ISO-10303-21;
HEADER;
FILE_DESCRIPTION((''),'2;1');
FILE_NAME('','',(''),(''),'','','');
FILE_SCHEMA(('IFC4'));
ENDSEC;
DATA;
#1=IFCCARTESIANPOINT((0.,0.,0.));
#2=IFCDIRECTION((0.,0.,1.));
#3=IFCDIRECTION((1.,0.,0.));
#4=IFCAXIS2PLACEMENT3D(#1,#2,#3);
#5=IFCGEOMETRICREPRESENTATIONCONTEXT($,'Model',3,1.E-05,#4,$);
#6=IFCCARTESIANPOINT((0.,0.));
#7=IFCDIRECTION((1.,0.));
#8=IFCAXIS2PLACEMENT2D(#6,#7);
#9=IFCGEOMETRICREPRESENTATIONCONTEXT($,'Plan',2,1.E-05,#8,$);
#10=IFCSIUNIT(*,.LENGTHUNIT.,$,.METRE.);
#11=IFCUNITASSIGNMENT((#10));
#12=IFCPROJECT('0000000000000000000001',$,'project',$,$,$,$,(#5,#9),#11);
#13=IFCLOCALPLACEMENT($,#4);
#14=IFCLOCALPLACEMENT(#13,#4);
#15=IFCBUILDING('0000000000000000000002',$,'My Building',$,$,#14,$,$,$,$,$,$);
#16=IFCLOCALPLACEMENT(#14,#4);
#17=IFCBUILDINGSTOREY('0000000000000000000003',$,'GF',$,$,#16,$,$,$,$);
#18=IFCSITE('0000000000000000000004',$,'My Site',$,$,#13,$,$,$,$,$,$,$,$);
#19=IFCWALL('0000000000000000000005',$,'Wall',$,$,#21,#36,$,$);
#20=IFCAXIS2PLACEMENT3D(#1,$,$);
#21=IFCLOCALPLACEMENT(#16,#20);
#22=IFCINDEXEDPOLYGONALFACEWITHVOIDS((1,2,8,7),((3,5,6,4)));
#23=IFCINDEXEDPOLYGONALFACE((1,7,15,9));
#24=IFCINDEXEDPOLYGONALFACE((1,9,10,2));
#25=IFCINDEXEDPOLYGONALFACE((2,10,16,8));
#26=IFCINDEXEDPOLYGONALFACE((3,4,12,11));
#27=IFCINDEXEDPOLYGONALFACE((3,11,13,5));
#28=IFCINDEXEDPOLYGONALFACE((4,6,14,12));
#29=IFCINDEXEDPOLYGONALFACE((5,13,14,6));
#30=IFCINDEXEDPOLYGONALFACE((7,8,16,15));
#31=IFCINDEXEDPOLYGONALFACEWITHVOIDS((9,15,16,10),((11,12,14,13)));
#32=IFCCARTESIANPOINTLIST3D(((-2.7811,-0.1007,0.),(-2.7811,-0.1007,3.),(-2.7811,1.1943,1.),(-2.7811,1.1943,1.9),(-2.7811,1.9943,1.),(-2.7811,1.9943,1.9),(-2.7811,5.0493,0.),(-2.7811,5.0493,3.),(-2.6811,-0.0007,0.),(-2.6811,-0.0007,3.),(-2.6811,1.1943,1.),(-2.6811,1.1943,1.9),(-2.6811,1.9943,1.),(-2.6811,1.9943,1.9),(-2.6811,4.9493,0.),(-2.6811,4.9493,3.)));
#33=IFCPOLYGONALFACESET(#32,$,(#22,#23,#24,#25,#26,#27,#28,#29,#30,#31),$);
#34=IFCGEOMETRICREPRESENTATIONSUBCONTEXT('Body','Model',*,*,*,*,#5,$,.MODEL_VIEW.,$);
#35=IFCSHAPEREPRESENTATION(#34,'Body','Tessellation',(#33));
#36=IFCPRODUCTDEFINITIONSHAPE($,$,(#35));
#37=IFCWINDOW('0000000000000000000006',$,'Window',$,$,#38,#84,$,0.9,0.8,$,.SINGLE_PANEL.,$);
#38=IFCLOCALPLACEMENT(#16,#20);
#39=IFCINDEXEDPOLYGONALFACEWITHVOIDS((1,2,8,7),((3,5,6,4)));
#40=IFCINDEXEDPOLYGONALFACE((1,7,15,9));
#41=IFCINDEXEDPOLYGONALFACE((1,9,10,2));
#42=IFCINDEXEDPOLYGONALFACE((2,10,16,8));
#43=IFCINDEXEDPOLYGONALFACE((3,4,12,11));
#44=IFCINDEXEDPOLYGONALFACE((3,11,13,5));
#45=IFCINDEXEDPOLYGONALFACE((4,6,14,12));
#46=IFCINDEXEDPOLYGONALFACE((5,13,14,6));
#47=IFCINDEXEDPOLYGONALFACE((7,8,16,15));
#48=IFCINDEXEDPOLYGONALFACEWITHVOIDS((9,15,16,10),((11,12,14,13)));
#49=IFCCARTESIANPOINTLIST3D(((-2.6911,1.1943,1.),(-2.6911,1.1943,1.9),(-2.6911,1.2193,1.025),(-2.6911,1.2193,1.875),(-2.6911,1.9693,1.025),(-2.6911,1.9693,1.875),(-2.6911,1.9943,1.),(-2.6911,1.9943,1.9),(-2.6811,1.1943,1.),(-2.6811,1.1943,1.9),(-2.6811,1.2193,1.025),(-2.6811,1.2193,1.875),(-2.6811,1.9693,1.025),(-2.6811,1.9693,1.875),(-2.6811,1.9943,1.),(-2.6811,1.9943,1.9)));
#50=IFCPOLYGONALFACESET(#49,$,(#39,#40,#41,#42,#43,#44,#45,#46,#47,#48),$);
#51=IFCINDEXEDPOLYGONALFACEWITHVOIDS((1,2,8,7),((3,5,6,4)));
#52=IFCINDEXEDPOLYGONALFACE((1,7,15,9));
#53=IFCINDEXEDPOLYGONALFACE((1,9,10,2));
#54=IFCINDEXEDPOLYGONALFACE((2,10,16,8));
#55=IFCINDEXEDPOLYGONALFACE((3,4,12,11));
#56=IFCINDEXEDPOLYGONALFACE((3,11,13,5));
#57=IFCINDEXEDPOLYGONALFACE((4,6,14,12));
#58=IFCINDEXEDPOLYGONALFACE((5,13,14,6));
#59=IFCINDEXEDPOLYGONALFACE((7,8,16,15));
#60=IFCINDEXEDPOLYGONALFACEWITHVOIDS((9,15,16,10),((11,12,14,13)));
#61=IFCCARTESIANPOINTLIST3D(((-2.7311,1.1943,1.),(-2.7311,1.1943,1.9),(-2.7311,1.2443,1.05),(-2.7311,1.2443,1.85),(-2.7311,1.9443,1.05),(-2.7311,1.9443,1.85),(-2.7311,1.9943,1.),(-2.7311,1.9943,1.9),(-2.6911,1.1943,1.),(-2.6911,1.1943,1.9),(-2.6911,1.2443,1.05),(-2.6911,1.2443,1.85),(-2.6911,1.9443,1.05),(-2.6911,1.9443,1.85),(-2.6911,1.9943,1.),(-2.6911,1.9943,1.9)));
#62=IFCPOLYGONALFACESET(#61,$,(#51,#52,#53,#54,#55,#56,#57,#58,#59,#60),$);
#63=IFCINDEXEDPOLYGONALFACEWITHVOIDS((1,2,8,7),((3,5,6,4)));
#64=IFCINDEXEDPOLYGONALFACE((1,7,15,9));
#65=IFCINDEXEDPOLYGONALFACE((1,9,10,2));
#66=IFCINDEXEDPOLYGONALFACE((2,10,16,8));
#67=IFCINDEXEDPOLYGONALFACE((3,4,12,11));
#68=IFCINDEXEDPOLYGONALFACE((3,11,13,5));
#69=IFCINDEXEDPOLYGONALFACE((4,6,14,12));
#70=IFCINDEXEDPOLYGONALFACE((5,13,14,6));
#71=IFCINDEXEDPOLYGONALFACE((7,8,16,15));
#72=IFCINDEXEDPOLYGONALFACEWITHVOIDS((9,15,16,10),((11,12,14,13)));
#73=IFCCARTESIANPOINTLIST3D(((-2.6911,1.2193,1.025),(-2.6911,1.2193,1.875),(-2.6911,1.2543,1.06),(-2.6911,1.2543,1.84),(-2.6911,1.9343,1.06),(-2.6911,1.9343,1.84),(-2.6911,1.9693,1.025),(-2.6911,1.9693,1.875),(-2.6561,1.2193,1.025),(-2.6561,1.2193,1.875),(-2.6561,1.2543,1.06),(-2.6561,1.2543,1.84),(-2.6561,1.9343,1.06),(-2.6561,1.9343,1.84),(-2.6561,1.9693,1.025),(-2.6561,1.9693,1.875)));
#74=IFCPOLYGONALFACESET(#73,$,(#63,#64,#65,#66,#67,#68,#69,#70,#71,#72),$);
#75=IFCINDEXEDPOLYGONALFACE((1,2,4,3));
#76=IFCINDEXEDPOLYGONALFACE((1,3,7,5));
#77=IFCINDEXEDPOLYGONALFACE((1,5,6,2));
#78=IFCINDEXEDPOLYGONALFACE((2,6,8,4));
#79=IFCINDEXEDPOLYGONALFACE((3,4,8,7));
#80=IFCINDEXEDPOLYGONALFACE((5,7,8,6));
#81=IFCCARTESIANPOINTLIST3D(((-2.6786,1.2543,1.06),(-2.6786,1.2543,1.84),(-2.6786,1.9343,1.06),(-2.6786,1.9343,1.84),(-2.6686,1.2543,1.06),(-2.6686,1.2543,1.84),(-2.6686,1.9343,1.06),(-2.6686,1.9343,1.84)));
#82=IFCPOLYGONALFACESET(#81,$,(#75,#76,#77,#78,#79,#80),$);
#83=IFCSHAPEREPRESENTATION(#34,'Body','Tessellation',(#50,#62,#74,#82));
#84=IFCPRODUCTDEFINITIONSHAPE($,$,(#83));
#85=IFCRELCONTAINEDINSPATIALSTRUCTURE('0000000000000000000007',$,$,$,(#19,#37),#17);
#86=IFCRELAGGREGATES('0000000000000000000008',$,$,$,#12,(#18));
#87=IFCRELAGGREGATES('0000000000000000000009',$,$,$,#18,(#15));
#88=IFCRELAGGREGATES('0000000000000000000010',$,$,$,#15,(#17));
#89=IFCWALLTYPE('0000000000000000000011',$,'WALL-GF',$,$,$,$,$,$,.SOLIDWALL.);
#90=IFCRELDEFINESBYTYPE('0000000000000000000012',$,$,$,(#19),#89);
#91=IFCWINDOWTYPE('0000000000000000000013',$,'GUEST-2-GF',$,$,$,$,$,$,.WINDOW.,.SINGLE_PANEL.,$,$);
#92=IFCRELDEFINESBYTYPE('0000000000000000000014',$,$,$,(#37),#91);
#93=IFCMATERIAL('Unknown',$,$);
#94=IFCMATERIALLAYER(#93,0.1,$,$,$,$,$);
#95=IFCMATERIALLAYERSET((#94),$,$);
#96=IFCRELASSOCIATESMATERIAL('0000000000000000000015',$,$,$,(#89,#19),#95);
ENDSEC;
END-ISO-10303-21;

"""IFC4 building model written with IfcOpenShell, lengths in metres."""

from ifc_helpers import new_model, entity, si_unit, frame, origin_with_axes, origin_2d_with_axis, place, context, subcontext, project, spatial, line, indexed_curve, outline, extrude, shape, source, transform, mapped, material, layer, layer_set, layer_usage, type_object, type_shapes, element, fill, save


model = new_model("IFC4")

# Units and contexts
model_context = context("Model", 3, precision=1e-05, world=origin_with_axes())
plan_context = context("Plan", 2, precision=1e-05, world=origin_2d_with_axis())
body_context_1 = subcontext(model_context, "Body", "Model", "MODEL_VIEW")
body_context_2 = subcontext(plan_context, "Body", "Plan", "PLAN_VIEW")
ifc_project = project(units=[si_unit("LENGTHUNIT", "METRE")], contexts=[model_context, plan_context])

# Site, building, storey
site_placement = place(None, origin_with_axes())
site = spatial("IfcSite", under=ifc_project, at=site_placement, Name="My Site")
building_placement = place(site_placement, origin_with_axes())
building = spatial("IfcBuilding", under=site, at=building_placement, Name="My Building")
storey_placement = place(building_placement, origin_with_axes())
storey = spatial("IfcBuildingStorey", under=building, at=storey_placement, Name="GF")

# Shared definitions
ifc_material = material(Name="Unknown")

# Shared definitions
ifc_layer_1 = layer(ifc_material, 0.1)
ifc_layer_set_1 = layer_set([ifc_layer_1])
wall_type = type_object("IfcWallType", Name="WALL-GF", PredefinedType="SOLIDWALL", material=ifc_layer_set_1)

# Wall, opening, window
ifc_layer_usage_1 = layer_usage(ifc_layer_set_1, "AXIS2", "POSITIVE", 0.0)
wall_1_placement = place(storey_placement, frame((-2.7811, 5.0493, 0.0), z_axis=(0.0, 0.0, 1.0), x_axis=(0.0, -1.0, 0.0)))
wall_1 = element("IfcWall", 1, at=wall_1_placement, inside=storey, type_object=wall_type, material=ifc_layer_usage_1, Name="Wall", context=body_context_1, shape_type="SweptSolid", body=[
    extrude(outline(indexed_curve([(0.0, 0.0), (0.1, 0.1), (5.05, 0.1), (5.15, 0.0)], segments=[line(1, 2, 3, 4, 1)])), origin_with_axes(), (0.0, 0.0, 1.0), 3.0),
])
shared_shape_1 = source(origin_with_axes(), body_context_1, "Body", "SweptSolid", [
    extrude(outline(indexed_curve([(0.0, 0.0), (0.8, 0.0), (0.8, 0.9), (0.0, 0.9)], segments=[line(1, 2, 3, 4, 1)])), frame((0.0, -0.6, 0.0), z_axis=(0.0, -1.0, 0.0), x_axis=(1.0, 0.0, 0.0)), (0.0, 0.0, -1.0), 1.2),
])
opening_1_placement = place(wall_1_placement, frame((3.0549, 0.0, 1.0), z_axis=(0.0, 0.0, 1.0), x_axis=(1.0, 0.0, 0.0)))
opening_1 = element("IfcOpeningElement", 2, at=opening_1_placement, cuts=wall_1, PredefinedType="OPENING", context=body_context_1, shape_type="MappedRepresentation", body=[
    mapped(shared_shape_1, transform((0.0, 0.0, 0.0), x_axis=(1.0, 0.0, 0.0), y_axis=(0.0, 1.0, 0.0), z_axis=(0.0, 0.0, 1.0), scale=1.0)),
])
window_type_1 = type_object("IfcWindowType", Name="GUEST-2-GF", PartitioningType="SINGLE_PANEL", PredefinedType="WINDOW")
shared_shape_2 = source(origin_with_axes(), body_context_1, "Body", "SweptSolid", [
    extrude(outline(indexed_curve([(0.0, 0.0), (0.8, 0.0), (0.8, 0.9), (0.0, 0.9)], segments=[line(1, 2, 3, 4, 1)]), holes=[indexed_curve([(0.025, 0.025), (0.775, 0.025), (0.775, 0.875), (0.025, 0.875)], segments=[line(1, 2, 3, 4, 1)])]), frame((0.0, 0.09, 0.0), z_axis=(0.0, -1.0, 0.0), x_axis=(1.0, 0.0, 0.0)), (0.0, 0.0, -1.0), 0.01),
    extrude(outline(indexed_curve([(0.0, 0.0), (0.8, 0.0), (0.8, 0.9), (0.0, 0.9)], segments=[line(1, 2, 3, 4, 1)]), holes=[indexed_curve([(0.05, 0.05), (0.75, 0.05), (0.75, 0.85), (0.05, 0.85)], segments=[line(1, 2, 3, 4, 1)])]), frame((0.0, 0.05, 0.0), z_axis=(0.0, -1.0, 0.0), x_axis=(1.0, 0.0, 0.0)), (0.0, 0.0, -1.0), 0.04),
    extrude(outline(indexed_curve([(0.0, 0.0), (0.75, 0.0), (0.75, 0.85), (0.0, 0.85)], segments=[line(1, 2, 3, 4, 1)]), holes=[indexed_curve([(0.035, 0.035), (0.715, 0.035), (0.715, 0.815), (0.035, 0.815)], segments=[line(1, 2, 3, 4, 1)])]), frame((0.025, 0.09, 0.025), z_axis=(0.0, -1.0, 0.0), x_axis=(1.0, 0.0, 0.0)), (0.0, 0.0, -1.0), 0.035),
    extrude(outline(indexed_curve([(0.035, 0.035), (0.715, 0.035), (0.715, 0.815), (0.035, 0.815)], segments=[line(1, 2, 3, 4, 1)])), frame((0.025, 0.1025, 0.025), z_axis=(0.0, -1.0, 0.0), x_axis=(1.0, 0.0, 0.0)), (0.0, 0.0, -1.0), 0.01),
])
shared_shape_3 = source(origin_with_axes(), body_context_2, "Body", "Curve2D", [
    entity("IfcIndexedPolyCurve", entity("IfcCartesianPointList2D", [[0.05, 0.05], [0.75, 0.05]])),
    entity("IfcIndexedPolyCurve", entity("IfcCartesianPointList2D", [[0.0, 0.1], [0.025, 0.1], [0.025, 0.09], [0.05, 0.09], [0.05, 0.05], [0.0, 0.05]]), [entity("IfcLineIndex", [1, 2, 3, 4, 5, 6, 1])]),
    entity("IfcIndexedPolyCurve", entity("IfcCartesianPointList2D", [[0.8, 0.1], [0.775, 0.1], [0.775, 0.09], [0.75, 0.09], [0.75, 0.05], [0.8, 0.05]]), [entity("IfcLineIndex", [1, 2, 3, 4, 5, 6, 1])]),
    entity("IfcIndexedPolyCurve", entity("IfcCartesianPointList2D", [[0.025, 0.09], [0.06, 0.09], [0.06, 0.125], [0.025, 0.125]]), [entity("IfcLineIndex", [1, 2, 3, 4, 1])]),
    entity("IfcIndexedPolyCurve", entity("IfcCartesianPointList2D", [[0.775, 0.09], [0.74, 0.09], [0.74, 0.125], [0.775, 0.125]]), [entity("IfcLineIndex", [1, 2, 3, 4, 1])]),
    entity("IfcIndexedPolyCurve", entity("IfcCartesianPointList2D", [[0.06, 0.09], [0.74, 0.09]])),
    entity("IfcIndexedPolyCurve", entity("IfcCartesianPointList2D", [[0.06, 0.125], [0.74, 0.125]])),
    entity("IfcIndexedPolyCurve", entity("IfcCartesianPointList2D", [[0.06, 0.1075], [0.74, 0.1075]])),
])
type_shapes(window_type_1, [shared_shape_2, shared_shape_3])
window_1_placement = place(opening_1_placement, frame((0.0, 0.0, 0.0), z_axis=(0.0, 0.0, 1.0), x_axis=(1.0, 0.0, 0.0)))
window_1 = element("IfcWindow", 3, at=window_1_placement, inside=storey, type_object=window_type_1, Name="Window", OverallHeight=0.9, OverallWidth=0.8, PartitioningType="SINGLE_PANEL", shapes=[
    shape(body_context_1, "Body", "MappedRepresentation", [mapped(shared_shape_2, transform((0.0, 0.0, 0.0), x_axis=(1.0, 0.0, 0.0), y_axis=(0.0, 1.0, 0.0), z_axis=(0.0, 0.0, 1.0), scale=1.0))]),
    shape(body_context_2, "Body", "MappedRepresentation", [mapped(shared_shape_3, transform((0.0, 0.0, 0.0), x_axis=(1.0, 0.0, 0.0), y_axis=(0.0, 1.0, 0.0), z_axis=(0.0, 0.0, 1.0), scale=1.0))]),
])
fill(opening_1, window_1)

save(model, "model.ifc")
